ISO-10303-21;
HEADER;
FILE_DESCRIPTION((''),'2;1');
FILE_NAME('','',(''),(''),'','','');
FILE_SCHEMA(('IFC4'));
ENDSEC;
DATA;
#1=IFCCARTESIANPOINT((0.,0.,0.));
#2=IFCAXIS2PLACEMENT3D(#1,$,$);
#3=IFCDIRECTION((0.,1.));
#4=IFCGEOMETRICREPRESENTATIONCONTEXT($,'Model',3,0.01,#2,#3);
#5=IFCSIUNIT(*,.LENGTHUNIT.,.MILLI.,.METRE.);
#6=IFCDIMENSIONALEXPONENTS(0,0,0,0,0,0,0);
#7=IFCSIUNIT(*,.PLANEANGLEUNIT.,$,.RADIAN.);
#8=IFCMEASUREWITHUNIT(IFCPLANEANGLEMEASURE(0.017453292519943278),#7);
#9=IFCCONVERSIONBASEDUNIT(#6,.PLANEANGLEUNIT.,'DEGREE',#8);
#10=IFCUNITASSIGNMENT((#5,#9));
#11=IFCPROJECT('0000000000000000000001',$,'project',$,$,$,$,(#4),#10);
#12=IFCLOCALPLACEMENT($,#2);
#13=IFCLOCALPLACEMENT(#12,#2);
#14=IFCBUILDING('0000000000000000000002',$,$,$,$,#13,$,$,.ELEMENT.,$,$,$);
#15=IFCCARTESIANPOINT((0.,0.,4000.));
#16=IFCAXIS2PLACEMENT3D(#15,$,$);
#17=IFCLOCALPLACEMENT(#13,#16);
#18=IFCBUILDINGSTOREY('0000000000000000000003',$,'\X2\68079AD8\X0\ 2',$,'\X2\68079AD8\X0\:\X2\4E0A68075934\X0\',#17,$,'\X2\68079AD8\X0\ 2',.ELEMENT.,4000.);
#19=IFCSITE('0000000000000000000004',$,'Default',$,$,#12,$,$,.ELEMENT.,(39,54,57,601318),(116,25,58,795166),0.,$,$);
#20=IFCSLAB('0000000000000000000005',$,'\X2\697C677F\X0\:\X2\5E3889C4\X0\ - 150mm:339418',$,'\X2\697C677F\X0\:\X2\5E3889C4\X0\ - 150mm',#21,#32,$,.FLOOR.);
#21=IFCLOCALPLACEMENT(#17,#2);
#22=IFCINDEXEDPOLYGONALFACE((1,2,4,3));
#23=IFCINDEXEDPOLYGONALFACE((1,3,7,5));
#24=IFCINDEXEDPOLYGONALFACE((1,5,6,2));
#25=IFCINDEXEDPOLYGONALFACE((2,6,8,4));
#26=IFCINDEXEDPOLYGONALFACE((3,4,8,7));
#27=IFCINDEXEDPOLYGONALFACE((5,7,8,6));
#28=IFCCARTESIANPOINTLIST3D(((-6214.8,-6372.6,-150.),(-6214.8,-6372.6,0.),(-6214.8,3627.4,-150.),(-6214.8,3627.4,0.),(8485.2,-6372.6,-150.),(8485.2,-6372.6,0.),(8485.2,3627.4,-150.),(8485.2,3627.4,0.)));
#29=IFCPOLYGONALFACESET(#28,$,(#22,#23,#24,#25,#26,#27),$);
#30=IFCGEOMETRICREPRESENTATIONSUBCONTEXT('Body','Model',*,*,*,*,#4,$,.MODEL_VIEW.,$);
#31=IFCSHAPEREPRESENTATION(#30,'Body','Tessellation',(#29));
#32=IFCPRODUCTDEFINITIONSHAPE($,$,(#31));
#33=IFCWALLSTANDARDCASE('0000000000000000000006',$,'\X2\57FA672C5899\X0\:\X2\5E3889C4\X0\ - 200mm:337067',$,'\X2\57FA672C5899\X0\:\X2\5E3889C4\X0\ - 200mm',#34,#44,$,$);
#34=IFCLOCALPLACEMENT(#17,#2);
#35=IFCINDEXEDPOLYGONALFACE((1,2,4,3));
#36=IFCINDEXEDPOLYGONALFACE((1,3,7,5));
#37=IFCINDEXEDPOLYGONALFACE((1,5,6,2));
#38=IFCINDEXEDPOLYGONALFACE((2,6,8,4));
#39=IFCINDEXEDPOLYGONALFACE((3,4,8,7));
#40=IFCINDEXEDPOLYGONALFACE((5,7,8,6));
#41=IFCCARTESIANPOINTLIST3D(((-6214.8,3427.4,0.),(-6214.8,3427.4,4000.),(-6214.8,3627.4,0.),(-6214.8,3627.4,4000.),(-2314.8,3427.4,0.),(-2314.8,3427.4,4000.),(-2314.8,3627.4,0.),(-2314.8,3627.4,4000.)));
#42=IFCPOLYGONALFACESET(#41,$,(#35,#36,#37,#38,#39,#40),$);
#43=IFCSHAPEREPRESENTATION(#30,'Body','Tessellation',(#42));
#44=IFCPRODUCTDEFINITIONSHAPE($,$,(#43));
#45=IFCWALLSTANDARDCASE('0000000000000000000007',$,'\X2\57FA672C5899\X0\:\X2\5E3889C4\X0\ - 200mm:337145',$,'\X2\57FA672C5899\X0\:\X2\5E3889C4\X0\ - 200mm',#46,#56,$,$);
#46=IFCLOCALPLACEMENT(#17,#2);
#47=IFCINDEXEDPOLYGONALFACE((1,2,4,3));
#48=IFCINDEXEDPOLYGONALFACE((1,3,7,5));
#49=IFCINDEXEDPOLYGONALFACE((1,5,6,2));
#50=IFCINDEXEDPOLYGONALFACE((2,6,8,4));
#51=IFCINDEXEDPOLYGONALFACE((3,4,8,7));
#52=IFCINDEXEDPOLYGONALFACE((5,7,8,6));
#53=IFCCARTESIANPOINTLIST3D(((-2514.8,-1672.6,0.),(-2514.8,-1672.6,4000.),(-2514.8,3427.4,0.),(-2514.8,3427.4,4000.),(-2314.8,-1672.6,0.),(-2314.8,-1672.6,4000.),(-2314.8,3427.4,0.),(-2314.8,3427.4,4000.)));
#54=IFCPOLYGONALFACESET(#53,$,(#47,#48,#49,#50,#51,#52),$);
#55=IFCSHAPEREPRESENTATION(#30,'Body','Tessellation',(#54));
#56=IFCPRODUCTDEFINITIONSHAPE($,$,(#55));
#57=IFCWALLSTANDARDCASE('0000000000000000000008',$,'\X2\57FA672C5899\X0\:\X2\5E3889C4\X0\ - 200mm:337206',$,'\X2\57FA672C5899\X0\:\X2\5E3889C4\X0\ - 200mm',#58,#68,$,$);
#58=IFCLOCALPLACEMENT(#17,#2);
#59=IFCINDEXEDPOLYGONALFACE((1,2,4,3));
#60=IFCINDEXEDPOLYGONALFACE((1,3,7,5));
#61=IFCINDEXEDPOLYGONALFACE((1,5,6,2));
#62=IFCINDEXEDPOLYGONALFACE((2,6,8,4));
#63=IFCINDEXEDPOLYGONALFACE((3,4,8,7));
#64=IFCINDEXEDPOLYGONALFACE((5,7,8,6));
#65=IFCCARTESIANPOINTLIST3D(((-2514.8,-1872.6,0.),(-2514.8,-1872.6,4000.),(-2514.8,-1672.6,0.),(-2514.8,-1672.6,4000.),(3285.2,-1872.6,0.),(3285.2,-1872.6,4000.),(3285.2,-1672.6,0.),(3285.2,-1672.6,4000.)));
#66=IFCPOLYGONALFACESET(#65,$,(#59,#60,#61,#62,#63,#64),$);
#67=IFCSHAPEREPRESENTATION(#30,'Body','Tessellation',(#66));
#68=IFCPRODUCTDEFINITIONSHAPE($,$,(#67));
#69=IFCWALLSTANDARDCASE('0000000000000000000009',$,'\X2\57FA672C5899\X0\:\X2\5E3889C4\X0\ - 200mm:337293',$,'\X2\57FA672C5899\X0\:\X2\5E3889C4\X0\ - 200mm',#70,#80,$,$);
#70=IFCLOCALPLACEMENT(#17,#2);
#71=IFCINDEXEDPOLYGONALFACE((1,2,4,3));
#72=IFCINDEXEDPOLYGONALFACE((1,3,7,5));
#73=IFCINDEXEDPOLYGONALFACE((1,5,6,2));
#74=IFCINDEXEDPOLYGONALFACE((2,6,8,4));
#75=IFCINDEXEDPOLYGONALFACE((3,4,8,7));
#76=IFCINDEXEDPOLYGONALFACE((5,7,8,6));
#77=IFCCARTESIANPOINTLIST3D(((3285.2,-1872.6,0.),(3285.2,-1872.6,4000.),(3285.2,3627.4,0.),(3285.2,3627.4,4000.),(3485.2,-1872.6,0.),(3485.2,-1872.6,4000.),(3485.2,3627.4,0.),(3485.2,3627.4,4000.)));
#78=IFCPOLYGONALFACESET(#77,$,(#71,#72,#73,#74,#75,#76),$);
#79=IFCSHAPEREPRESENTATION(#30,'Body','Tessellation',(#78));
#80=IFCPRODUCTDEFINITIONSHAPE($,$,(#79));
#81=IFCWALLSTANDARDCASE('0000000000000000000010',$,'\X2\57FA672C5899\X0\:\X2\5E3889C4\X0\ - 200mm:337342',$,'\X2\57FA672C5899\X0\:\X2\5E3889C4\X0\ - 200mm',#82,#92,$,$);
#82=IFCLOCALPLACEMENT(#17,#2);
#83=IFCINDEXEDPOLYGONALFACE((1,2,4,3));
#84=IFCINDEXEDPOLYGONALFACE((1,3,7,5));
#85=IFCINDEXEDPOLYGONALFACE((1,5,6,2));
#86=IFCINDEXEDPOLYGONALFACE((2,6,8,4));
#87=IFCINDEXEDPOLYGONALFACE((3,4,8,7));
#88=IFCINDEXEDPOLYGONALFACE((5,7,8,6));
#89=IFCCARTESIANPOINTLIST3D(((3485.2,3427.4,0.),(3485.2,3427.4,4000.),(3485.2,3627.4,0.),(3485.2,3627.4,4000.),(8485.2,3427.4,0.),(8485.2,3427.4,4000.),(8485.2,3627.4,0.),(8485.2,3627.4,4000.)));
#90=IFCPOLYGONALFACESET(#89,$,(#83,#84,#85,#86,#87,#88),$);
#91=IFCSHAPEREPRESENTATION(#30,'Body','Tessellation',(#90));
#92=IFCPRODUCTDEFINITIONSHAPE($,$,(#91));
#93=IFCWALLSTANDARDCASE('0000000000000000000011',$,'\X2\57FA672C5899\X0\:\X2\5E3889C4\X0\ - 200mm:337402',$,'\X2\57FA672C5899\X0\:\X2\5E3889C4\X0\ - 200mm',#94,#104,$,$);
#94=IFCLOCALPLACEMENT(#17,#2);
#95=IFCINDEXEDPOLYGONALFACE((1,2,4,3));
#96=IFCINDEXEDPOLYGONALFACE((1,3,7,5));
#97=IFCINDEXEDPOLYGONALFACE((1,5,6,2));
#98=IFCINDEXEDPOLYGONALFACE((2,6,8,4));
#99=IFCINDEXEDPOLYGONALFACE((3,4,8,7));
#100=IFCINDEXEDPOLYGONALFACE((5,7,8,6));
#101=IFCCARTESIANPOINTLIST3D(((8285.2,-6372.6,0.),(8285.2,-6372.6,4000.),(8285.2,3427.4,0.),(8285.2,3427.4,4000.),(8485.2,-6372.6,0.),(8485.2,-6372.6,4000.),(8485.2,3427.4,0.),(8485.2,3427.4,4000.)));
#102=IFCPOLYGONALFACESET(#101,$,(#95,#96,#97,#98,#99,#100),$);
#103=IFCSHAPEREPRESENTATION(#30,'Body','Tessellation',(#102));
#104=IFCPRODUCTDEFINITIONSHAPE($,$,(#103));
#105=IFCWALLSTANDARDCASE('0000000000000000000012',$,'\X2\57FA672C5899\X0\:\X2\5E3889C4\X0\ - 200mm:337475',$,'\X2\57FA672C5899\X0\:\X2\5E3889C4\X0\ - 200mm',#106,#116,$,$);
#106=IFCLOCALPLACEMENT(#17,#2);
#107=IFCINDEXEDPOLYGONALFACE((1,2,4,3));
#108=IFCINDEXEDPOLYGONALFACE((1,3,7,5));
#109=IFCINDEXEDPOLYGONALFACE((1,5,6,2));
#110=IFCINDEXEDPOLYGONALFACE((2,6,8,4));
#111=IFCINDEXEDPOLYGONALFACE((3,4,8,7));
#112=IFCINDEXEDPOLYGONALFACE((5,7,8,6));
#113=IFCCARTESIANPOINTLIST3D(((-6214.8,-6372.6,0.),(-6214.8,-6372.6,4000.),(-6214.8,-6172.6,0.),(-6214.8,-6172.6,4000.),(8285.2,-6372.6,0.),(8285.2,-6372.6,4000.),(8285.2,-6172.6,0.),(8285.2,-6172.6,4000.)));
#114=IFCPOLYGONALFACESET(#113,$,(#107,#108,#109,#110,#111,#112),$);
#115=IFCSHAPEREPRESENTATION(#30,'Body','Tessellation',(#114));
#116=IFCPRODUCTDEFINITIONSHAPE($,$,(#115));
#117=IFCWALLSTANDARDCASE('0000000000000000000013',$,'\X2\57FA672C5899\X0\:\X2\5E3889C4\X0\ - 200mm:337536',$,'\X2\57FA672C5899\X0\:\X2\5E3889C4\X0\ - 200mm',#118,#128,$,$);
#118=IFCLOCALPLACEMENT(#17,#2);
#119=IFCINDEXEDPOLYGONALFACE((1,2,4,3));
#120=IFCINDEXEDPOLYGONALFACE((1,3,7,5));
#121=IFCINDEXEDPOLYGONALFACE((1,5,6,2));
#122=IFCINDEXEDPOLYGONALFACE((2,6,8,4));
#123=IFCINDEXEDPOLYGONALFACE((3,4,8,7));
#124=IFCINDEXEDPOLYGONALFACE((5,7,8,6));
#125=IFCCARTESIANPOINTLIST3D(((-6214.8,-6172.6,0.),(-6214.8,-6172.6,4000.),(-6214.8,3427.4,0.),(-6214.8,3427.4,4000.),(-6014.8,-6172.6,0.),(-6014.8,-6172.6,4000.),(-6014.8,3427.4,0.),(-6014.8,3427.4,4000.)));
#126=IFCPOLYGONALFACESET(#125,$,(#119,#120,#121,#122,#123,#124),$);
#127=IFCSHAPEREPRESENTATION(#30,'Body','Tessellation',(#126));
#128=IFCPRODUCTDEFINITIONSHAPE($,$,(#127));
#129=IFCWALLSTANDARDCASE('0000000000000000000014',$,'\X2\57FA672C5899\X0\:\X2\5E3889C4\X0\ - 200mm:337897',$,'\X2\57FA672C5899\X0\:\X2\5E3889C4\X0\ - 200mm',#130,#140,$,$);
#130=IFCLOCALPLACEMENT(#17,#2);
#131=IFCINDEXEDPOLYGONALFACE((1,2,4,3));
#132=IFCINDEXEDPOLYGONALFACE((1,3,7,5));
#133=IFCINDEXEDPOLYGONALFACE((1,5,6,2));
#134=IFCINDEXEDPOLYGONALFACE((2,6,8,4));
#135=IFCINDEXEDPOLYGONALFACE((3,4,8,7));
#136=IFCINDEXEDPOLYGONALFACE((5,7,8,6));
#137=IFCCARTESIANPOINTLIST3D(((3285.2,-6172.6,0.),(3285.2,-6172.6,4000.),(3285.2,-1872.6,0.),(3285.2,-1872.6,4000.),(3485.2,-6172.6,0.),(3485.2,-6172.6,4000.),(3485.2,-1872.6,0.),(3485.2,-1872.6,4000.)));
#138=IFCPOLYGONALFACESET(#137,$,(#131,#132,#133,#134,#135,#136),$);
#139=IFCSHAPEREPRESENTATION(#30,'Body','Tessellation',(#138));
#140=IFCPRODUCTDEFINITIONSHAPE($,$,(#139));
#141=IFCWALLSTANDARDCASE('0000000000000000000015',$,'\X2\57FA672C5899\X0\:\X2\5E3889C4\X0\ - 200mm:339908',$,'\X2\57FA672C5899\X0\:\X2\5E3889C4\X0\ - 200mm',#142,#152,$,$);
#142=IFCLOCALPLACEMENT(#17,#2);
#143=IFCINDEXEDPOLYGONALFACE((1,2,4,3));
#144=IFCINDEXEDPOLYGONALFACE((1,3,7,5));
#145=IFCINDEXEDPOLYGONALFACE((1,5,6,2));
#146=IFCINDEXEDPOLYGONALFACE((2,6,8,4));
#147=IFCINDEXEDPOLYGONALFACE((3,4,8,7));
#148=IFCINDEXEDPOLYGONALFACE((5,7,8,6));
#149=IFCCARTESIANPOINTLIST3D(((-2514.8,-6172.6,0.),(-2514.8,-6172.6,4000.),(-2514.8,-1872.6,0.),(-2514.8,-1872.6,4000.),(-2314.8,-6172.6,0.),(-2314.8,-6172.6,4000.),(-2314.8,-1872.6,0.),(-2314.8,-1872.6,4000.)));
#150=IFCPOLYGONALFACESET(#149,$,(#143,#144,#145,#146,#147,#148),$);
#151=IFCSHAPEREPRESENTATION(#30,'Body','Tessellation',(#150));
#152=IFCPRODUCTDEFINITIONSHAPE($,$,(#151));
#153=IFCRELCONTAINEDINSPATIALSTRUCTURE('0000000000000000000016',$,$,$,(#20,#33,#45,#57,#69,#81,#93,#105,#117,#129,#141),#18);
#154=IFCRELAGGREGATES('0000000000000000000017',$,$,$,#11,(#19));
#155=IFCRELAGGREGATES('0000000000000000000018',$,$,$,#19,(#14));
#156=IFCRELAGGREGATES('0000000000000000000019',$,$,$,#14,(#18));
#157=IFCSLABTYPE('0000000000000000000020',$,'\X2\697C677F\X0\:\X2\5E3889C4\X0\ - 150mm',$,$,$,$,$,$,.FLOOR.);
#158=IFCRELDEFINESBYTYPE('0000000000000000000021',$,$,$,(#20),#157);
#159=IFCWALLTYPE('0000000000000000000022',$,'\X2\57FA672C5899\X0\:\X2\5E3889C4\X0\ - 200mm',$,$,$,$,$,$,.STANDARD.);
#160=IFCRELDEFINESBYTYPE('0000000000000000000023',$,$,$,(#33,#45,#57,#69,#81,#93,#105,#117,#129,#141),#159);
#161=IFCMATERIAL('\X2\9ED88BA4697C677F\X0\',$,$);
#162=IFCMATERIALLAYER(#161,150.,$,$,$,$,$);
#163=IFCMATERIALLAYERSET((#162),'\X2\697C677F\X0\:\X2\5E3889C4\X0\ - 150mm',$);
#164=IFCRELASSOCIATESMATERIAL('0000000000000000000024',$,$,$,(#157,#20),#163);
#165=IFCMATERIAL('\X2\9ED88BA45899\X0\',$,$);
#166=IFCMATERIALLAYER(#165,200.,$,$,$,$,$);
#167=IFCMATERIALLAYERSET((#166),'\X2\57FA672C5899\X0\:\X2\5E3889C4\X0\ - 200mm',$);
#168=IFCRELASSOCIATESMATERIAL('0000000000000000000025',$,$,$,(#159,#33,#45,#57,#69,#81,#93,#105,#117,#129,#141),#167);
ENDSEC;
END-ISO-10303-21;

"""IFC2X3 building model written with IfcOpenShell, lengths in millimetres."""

from ifc_helpers import new_model, entity, si_unit, converted_unit, direction, frame, frame_2d, origin, origin_2d_with_axis, place, context, subcontext, project, spatial, rectangle, extrude, material, layer, layer_set, layer_usage, type_object, element, save


model = new_model("IFC2X3")

# Units and contexts
model_context = context("Model", 3, precision=0.01, world=origin(), true_north=direction((0.0, 1.0)))
body_context = subcontext(model_context, "Body", "Model", "MODEL_VIEW")
ifc_project = project(units=[si_unit("LENGTHUNIT", "METRE", prefix="MILLI"), converted_unit("PLANEANGLEUNIT", "DEGREE", entity("IfcPlaneAngleMeasure", 0.017453292519943278), si_unit("PLANEANGLEUNIT", "RADIAN"), dimensions=[0, 0, 0, 0, 0, 0, 0])], contexts=[model_context])

# Site, building, storey
site_placement = place(None, origin())
site = spatial("IfcSite", under=ifc_project, at=site_placement, Name="Default", CompositionType="ELEMENT", RefLatitude=(39, 54, 57, 601318), RefLongitude=(116, 25, 58, 795166), RefElevation=0.0)
building_placement = place(site_placement, origin())
building = spatial("IfcBuilding", under=site, at=building_placement, CompositionType="ELEMENT")
storey_placement = place(building_placement, frame((0.0, 0.0, 4000.0)))
storey = spatial("IfcBuildingStorey", under=building, at=storey_placement, Name="标高 2", ObjectType="标高:上标头", LongName="标高 2", CompositionType="ELEMENT", Elevation=4000.0)

# Slab
ifc_material_1 = material(Name="默认楼板")
ifc_layer_1 = layer(ifc_material_1, 150.0)
ifc_layer_set_1 = layer_set([ifc_layer_1], Name="楼板:常规 - 150mm")
ifc_layer_usage_1 = layer_usage(ifc_layer_set_1, "AXIS3", "POSITIVE", 0.0)
slab_type = type_object("IfcSlabType", Name="楼板:常规 - 150mm", PredefinedType="FLOOR", material=ifc_layer_set_1)
slab_placement = place(storey_placement, origin())
element("IfcSlab", 1, at=slab_placement, inside=storey, type_object=slab_type, material=ifc_layer_usage_1, Name="楼板:常规 - 150mm:339418", ObjectType="楼板:常规 - 150mm", PredefinedType="FLOOR", context=body_context, shape_type="SweptSolid", body=[
    extrude(rectangle(XDim=10000.0, YDim=14700.0, at=origin_2d_with_axis()), frame((1135.2, -1372.6, 0.0), z_axis=(0.0, 0.0, -1.0), x_axis=(0.0, 1.0, 0.0)), (0.0, 0.0, 1.0), 150.0),
])

# Walls
ifc_material_2 = material(Name="默认墙")
ifc_layer_2 = layer(ifc_material_2, 200.0)
ifc_layer_set_2 = layer_set([ifc_layer_2], Name="基本墙:常规 - 200mm")
ifc_layer_usage_2 = layer_usage(ifc_layer_set_2, "AXIS2", "NEGATIVE", 100.0)
wall_type = type_object("IfcWallType", Name="基本墙:常规 - 200mm", PredefinedType="STANDARD", material=ifc_layer_set_2)
wall_1_placement = place(storey_placement, frame((-6214.8, 3527.4, 0.0)))
element("IfcWallStandardCase", 2, at=wall_1_placement, inside=storey, type_object=wall_type, material=ifc_layer_usage_2, Name="基本墙:常规 - 200mm:337067", ObjectType="基本墙:常规 - 200mm", context=body_context, shape_type="SweptSolid", body=[
    extrude(rectangle(XDim=3900.0, YDim=200.0, at=frame_2d((1950.0, 0.0), x_axis=(-1.0, 0.0))), origin(), (0.0, 0.0, 1.0), 4000.0),
])
ifc_layer_usage_3 = layer_usage(ifc_layer_set_2, "AXIS2", "NEGATIVE", 100.0)
wall_2_placement = place(storey_placement, frame((-2414.8, 3427.4, 0.0), z_axis=(0.0, 0.0, 1.0), x_axis=(0.0, -1.0, 0.0)))
element("IfcWallStandardCase", 3, at=wall_2_placement, inside=storey, type_object=wall_type, material=ifc_layer_usage_3, Name="基本墙:常规 - 200mm:337145", ObjectType="基本墙:常规 - 200mm", context=body_context, shape_type="SweptSolid", body=[
    extrude(rectangle(XDim=5100.0, YDim=200.0, at=frame_2d((2550.0, 0.0), x_axis=(-1.0, 0.0))), origin(), (0.0, 0.0, 1.0), 4000.0),
])
ifc_layer_usage_4 = layer_usage(ifc_layer_set_2, "AXIS2", "NEGATIVE", 100.0)
wall_3_placement = place(storey_placement, frame((-2514.8, -1772.6, 0.0)))
element("IfcWallStandardCase", 4, at=wall_3_placement, inside=storey, type_object=wall_type, material=ifc_layer_usage_4, Name="基本墙:常规 - 200mm:337206", ObjectType="基本墙:常规 - 200mm", context=body_context, shape_type="SweptSolid", body=[
    extrude(rectangle(XDim=5800.0, YDim=200.0, at=frame_2d((2900.0, 0.0), x_axis=(-1.0, 0.0))), origin(), (0.0, 0.0, 1.0), 4000.0),
])
ifc_layer_usage_5 = layer_usage(ifc_layer_set_2, "AXIS2", "NEGATIVE", 100.0)
wall_4_placement = place(storey_placement, frame((3385.2, -1872.6, 0.0), z_axis=(0.0, 0.0, 1.0), x_axis=(0.0, 1.0, 0.0)))
element("IfcWallStandardCase", 5, at=wall_4_placement, inside=storey, type_object=wall_type, material=ifc_layer_usage_5, Name="基本墙:常规 - 200mm:337293", ObjectType="基本墙:常规 - 200mm", context=body_context, shape_type="SweptSolid", body=[
    extrude(rectangle(XDim=5500.0, YDim=200.0, at=frame_2d((2750.0, 0.0), x_axis=(-1.0, 0.0))), origin(), (0.0, 0.0, 1.0), 4000.0),
])
ifc_layer_usage_6 = layer_usage(ifc_layer_set_2, "AXIS2", "NEGATIVE", 100.0)
wall_5_placement = place(storey_placement, frame((3485.2, 3527.4, 0.0)))
element("IfcWallStandardCase", 6, at=wall_5_placement, inside=storey, type_object=wall_type, material=ifc_layer_usage_6, Name="基本墙:常规 - 200mm:337342", ObjectType="基本墙:常规 - 200mm", context=body_context, shape_type="SweptSolid", body=[
    extrude(rectangle(XDim=5000.0, YDim=200.0, at=frame_2d((2500.0, 0.0), x_axis=(-1.0, 0.0))), origin(), (0.0, 0.0, 1.0), 4000.0),
])
ifc_layer_usage_7 = layer_usage(ifc_layer_set_2, "AXIS2", "NEGATIVE", 100.0)
wall_6_placement = place(storey_placement, frame((8385.2, 3427.4, 0.0), z_axis=(0.0, 0.0, 1.0), x_axis=(0.0, -1.0, 0.0)))
element("IfcWallStandardCase", 7, at=wall_6_placement, inside=storey, type_object=wall_type, material=ifc_layer_usage_7, Name="基本墙:常规 - 200mm:337402", ObjectType="基本墙:常规 - 200mm", context=body_context, shape_type="SweptSolid", body=[
    extrude(rectangle(XDim=9800.0, YDim=200.0, at=frame_2d((4900.0, 0.0), x_axis=(-1.0, 0.0))), origin(), (0.0, 0.0, 1.0), 4000.0),
])
ifc_layer_usage_8 = layer_usage(ifc_layer_set_2, "AXIS2", "NEGATIVE", 100.0)
wall_7_placement = place(storey_placement, frame((8285.2, -6272.6, 0.0), z_axis=(0.0, 0.0, 1.0), x_axis=(-1.0, 0.0, 0.0)))
element("IfcWallStandardCase", 8, at=wall_7_placement, inside=storey, type_object=wall_type, material=ifc_layer_usage_8, Name="基本墙:常规 - 200mm:337475", ObjectType="基本墙:常规 - 200mm", context=body_context, shape_type="SweptSolid", body=[
    extrude(rectangle(XDim=14500.0, YDim=200.0, at=frame_2d((7250.0, 0.0), x_axis=(-1.0, 0.0))), origin(), (0.0, 0.0, 1.0), 4000.0),
])
ifc_layer_usage_9 = layer_usage(ifc_layer_set_2, "AXIS2", "NEGATIVE", 100.0)
wall_8_placement = place(storey_placement, frame((-6114.8, -6172.6, 0.0), z_axis=(0.0, 0.0, 1.0), x_axis=(0.0, 1.0, 0.0)))
element("IfcWallStandardCase", 9, at=wall_8_placement, inside=storey, type_object=wall_type, material=ifc_layer_usage_9, Name="基本墙:常规 - 200mm:337536", ObjectType="基本墙:常规 - 200mm", context=body_context, shape_type="SweptSolid", body=[
    extrude(rectangle(XDim=9600.0, YDim=200.0, at=frame_2d((4800.0, 0.0), x_axis=(-1.0, 0.0))), origin(), (0.0, 0.0, 1.0), 4000.0),
])
ifc_layer_usage_10 = layer_usage(ifc_layer_set_2, "AXIS2", "NEGATIVE", 100.0)
wall_9_placement = place(storey_placement, frame((3385.2, -1872.6, 0.0), z_axis=(0.0, 0.0, 1.0), x_axis=(0.0, -1.0, 0.0)))
element("IfcWallStandardCase", 10, at=wall_9_placement, inside=storey, type_object=wall_type, material=ifc_layer_usage_10, Name="基本墙:常规 - 200mm:337897", ObjectType="基本墙:常规 - 200mm", context=body_context, shape_type="SweptSolid", body=[
    extrude(rectangle(XDim=4300.0, YDim=200.0, at=frame_2d((2150.0, 0.0), x_axis=(-1.0, 0.0))), origin(), (0.0, 0.0, 1.0), 4000.0),
])
ifc_layer_usage_11 = layer_usage(ifc_layer_set_2, "AXIS2", "NEGATIVE", 100.0)
wall_10_placement = place(storey_placement, frame((-2414.8, -1872.6, 0.0), z_axis=(0.0, 0.0, 1.0), x_axis=(0.0, -1.0, 0.0)))
element("IfcWallStandardCase", 11, at=wall_10_placement, inside=storey, type_object=wall_type, material=ifc_layer_usage_11, Name="基本墙:常规 - 200mm:339908", ObjectType="基本墙:常规 - 200mm", context=body_context, shape_type="SweptSolid", body=[
    extrude(rectangle(XDim=4300.0, YDim=200.0, at=frame_2d((2150.0, 0.0), x_axis=(-1.0, 0.0))), origin(), (0.0, 0.0, 1.0), 4000.0),
])

save(model, "model.ifc")
